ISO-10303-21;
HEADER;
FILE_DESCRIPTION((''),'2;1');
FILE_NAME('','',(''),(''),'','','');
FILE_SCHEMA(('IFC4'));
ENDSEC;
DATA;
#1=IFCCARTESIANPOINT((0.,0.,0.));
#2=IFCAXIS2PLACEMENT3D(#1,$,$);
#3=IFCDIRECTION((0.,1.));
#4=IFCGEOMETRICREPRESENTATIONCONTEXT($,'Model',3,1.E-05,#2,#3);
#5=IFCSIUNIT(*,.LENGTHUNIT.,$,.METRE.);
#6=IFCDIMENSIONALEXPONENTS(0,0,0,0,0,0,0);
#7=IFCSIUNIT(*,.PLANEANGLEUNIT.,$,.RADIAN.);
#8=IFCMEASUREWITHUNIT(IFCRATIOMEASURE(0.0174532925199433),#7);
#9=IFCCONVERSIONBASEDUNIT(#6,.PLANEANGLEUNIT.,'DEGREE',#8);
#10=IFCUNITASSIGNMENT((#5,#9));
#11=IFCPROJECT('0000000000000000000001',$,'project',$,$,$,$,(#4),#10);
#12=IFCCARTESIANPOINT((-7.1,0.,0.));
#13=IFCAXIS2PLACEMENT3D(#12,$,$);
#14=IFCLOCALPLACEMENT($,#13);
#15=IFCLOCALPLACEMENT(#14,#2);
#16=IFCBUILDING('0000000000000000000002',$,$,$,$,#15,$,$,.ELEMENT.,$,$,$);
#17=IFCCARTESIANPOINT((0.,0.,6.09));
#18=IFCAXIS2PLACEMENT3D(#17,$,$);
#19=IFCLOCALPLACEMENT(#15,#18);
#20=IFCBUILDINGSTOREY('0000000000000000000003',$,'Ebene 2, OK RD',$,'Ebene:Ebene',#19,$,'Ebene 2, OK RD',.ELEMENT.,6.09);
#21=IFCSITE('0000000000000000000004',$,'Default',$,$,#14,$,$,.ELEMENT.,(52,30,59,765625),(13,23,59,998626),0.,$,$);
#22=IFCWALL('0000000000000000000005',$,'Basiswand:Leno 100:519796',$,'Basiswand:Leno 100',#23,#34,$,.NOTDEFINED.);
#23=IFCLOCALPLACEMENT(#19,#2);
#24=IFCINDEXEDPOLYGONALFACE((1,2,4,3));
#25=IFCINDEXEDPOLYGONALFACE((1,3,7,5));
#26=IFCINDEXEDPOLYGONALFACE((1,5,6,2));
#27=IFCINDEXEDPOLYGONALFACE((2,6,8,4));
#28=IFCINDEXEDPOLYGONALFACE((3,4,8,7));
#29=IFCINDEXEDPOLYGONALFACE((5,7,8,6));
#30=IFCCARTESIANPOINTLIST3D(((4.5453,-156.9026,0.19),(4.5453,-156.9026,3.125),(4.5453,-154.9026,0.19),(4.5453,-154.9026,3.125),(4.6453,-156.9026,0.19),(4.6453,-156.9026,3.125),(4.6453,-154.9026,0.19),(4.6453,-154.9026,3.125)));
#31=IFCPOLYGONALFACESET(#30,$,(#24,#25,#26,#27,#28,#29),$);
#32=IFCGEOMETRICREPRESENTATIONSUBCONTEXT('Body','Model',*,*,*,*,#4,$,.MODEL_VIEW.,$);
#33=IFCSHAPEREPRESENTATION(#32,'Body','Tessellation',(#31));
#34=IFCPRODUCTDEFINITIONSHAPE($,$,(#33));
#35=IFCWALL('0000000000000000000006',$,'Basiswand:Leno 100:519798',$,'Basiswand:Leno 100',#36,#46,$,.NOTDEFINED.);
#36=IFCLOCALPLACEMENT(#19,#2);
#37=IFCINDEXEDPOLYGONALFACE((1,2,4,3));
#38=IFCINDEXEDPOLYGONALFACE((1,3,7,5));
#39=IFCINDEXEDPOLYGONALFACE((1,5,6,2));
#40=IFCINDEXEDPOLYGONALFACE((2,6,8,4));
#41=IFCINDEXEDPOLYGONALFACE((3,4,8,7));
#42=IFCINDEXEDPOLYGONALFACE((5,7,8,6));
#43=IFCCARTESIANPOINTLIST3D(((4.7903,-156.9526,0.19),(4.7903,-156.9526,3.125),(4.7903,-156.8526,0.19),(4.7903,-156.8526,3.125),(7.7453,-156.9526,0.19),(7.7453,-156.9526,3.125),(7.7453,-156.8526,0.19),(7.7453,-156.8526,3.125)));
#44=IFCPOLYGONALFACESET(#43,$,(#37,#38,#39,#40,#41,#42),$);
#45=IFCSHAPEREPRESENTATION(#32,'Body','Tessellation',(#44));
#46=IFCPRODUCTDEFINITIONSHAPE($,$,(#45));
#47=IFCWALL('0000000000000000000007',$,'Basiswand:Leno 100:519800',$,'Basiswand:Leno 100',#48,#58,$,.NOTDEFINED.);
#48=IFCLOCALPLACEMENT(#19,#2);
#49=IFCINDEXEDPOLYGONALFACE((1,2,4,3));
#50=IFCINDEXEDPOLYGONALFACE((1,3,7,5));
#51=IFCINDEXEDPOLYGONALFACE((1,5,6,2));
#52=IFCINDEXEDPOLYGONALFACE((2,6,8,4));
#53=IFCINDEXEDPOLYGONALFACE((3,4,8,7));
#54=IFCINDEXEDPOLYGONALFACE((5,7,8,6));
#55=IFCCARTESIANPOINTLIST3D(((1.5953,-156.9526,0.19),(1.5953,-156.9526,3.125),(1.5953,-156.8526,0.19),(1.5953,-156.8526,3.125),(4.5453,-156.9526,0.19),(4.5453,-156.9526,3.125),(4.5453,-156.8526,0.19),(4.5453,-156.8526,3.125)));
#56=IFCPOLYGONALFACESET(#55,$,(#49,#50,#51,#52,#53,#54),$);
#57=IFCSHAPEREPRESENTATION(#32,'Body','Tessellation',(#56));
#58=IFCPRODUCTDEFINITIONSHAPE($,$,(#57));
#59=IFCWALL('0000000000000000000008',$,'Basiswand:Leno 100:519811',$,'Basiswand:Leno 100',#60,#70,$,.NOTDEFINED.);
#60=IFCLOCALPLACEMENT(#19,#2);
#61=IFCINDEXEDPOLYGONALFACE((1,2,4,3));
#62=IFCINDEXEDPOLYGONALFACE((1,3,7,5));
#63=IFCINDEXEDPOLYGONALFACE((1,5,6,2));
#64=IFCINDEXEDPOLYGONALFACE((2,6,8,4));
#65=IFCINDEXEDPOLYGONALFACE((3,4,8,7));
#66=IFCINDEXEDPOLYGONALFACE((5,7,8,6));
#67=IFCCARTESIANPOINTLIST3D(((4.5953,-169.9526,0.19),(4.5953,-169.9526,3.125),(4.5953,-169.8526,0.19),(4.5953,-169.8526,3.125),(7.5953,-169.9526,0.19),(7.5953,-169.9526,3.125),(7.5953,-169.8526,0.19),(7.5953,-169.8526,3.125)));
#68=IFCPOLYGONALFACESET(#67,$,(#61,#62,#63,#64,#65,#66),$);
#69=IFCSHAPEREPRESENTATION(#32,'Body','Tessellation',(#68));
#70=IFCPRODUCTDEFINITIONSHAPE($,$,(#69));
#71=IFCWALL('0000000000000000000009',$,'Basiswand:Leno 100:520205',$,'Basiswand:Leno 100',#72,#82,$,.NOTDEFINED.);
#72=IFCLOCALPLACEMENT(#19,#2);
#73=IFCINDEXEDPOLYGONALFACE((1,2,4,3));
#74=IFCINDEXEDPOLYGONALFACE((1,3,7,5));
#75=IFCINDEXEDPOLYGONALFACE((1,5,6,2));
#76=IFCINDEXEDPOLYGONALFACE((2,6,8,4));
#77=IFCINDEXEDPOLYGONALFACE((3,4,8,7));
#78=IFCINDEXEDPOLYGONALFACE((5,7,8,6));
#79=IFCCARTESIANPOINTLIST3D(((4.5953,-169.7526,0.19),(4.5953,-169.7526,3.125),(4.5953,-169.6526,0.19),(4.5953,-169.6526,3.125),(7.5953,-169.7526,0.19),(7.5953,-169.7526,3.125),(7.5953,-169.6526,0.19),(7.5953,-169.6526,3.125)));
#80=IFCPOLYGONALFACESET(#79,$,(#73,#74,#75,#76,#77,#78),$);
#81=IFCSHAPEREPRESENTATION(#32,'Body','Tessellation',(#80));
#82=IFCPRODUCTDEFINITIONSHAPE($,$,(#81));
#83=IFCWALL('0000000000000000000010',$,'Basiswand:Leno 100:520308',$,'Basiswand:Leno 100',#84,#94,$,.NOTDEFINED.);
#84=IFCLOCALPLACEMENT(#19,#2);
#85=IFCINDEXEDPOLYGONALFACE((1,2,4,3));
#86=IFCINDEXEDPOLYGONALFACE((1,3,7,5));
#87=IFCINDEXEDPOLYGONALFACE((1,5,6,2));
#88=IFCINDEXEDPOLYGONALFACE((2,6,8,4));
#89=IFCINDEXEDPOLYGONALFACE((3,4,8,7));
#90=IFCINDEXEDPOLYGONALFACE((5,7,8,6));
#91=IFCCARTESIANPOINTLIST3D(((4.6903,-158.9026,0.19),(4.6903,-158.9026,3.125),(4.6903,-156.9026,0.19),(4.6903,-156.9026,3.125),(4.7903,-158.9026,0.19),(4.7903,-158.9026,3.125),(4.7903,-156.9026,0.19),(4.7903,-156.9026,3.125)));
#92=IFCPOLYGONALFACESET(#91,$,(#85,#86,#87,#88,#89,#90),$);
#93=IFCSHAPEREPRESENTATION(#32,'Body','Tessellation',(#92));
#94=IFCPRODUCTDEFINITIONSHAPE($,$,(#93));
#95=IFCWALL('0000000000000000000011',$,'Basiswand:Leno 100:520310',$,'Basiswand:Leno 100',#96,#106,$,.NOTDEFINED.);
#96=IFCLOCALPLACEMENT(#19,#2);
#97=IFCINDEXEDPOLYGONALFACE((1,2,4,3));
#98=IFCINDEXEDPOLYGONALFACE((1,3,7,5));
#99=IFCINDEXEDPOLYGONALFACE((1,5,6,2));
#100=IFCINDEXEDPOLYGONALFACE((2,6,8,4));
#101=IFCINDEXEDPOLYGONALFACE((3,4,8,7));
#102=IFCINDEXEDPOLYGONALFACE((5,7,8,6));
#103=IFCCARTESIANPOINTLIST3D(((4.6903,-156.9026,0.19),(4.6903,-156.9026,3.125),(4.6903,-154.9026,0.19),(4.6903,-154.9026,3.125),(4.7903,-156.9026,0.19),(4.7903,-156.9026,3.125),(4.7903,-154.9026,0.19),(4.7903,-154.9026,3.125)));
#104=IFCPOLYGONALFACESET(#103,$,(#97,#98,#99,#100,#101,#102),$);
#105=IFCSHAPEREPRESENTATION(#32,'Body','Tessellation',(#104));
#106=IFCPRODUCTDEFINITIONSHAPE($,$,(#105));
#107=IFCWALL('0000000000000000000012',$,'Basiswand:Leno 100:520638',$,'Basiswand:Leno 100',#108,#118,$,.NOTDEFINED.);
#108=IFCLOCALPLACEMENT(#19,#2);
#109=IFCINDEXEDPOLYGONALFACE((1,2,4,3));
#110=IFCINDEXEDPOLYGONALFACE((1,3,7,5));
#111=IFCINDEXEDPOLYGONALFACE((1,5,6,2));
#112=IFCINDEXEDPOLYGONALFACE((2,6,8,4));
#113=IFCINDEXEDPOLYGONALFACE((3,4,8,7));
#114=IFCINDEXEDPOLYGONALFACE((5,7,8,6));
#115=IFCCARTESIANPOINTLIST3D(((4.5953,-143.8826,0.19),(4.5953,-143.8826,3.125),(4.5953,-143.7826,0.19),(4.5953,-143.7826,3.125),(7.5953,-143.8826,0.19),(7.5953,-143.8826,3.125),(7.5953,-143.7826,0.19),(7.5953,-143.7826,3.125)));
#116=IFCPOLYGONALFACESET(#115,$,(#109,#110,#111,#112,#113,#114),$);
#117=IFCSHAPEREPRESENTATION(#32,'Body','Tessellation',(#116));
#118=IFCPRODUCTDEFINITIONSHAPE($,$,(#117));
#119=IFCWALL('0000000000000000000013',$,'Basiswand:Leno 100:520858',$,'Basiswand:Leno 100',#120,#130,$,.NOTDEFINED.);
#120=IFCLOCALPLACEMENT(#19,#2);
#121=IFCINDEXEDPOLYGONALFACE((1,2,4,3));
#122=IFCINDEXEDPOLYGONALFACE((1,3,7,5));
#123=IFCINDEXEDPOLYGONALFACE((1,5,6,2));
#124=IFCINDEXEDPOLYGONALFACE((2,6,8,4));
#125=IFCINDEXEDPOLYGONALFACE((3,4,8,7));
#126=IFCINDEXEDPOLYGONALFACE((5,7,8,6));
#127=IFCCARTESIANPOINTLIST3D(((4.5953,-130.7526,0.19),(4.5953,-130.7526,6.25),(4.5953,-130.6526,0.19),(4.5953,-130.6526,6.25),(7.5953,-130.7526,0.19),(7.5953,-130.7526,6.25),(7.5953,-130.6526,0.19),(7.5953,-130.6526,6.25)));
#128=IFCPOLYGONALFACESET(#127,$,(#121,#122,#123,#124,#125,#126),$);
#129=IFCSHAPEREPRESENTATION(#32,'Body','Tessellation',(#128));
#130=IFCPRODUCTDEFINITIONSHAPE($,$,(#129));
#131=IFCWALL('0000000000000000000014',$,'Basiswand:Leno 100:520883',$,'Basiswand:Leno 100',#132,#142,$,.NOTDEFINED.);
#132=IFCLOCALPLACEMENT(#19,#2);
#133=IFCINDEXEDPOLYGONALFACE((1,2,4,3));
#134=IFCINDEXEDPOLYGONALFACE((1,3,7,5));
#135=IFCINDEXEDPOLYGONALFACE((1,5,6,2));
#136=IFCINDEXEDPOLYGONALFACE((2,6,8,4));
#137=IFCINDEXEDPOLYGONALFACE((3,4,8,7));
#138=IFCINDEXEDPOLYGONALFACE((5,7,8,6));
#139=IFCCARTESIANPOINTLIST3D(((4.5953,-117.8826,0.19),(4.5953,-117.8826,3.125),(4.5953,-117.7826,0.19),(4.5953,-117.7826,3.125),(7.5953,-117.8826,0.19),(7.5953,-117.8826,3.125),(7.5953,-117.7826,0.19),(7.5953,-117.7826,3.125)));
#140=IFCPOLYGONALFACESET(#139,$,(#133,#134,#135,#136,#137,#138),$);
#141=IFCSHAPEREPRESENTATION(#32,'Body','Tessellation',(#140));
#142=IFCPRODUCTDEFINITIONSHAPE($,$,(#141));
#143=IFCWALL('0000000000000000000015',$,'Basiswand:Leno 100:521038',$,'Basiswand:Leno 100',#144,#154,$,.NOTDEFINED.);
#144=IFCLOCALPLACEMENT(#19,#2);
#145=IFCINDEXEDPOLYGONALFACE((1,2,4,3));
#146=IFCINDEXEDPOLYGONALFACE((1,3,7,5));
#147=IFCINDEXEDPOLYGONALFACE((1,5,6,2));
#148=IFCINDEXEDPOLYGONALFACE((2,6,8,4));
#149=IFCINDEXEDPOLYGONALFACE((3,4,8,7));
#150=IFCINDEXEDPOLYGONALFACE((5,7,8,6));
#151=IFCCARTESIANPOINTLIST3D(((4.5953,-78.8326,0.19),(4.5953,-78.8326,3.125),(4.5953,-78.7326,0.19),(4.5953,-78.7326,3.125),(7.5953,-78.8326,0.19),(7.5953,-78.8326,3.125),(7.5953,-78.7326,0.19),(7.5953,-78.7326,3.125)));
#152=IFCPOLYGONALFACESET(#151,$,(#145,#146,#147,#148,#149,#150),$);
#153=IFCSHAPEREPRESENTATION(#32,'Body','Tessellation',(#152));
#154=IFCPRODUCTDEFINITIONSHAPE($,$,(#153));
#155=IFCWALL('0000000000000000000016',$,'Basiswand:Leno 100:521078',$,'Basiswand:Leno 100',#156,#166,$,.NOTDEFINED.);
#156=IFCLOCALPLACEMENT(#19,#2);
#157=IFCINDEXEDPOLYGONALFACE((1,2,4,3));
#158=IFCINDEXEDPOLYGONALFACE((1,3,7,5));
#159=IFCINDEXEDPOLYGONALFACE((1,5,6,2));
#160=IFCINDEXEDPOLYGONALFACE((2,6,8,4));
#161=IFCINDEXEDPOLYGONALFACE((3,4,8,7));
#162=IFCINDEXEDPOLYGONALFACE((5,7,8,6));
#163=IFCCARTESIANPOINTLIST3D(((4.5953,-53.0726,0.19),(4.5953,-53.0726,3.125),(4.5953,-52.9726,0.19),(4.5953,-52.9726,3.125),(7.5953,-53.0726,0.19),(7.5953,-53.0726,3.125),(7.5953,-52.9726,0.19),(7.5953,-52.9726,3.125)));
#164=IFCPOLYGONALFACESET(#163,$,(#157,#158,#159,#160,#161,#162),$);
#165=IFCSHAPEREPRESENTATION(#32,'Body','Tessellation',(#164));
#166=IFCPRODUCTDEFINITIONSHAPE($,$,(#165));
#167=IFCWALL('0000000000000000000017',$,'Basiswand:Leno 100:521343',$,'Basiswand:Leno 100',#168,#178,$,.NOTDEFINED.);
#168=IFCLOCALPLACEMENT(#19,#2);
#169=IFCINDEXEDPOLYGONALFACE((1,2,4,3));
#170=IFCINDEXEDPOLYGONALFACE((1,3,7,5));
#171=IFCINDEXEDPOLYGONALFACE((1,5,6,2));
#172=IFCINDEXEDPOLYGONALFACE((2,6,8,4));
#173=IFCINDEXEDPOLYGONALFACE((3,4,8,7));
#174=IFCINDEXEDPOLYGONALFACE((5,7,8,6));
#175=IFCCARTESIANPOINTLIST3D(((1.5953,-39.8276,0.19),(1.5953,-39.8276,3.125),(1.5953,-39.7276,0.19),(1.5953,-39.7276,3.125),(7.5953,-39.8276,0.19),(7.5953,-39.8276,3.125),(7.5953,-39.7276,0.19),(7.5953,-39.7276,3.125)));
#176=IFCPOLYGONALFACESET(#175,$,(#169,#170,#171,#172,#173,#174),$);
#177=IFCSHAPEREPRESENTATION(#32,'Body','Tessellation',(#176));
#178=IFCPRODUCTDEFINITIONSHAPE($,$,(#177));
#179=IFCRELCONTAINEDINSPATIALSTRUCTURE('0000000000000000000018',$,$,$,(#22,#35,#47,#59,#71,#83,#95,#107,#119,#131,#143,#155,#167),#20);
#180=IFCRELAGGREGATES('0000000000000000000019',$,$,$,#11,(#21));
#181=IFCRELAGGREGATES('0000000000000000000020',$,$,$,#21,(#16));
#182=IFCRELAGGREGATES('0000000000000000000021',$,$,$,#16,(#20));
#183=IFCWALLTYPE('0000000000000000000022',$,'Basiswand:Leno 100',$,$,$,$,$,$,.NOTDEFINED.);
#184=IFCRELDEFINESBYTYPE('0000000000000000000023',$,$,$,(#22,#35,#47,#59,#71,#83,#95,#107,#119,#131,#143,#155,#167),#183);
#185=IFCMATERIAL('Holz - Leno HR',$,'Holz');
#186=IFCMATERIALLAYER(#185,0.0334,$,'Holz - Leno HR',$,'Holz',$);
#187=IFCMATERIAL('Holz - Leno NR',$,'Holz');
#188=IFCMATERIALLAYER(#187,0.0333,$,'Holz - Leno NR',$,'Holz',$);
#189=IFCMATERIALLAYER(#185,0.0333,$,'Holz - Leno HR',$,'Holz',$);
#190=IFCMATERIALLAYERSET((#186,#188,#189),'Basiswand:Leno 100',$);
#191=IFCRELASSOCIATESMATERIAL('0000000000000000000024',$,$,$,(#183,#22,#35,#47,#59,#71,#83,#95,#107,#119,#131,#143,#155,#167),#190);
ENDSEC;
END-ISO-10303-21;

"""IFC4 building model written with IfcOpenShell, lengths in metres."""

from ifc_helpers import new_model, entity, si_unit, converted_unit, direction, frame, origin, place, context, subcontext, project, spatial, indexed_curve, outline, extrude, material, layer, layer_set, type_object, element, save


model = new_model("IFC4")

# Units and contexts
model_context = context("Model", 3, precision=1e-05, world=origin(), true_north=direction((0.0, 1.0)))
body_context = subcontext(model_context, "Body", "Model", "MODEL_VIEW")
ifc_project = project(units=[si_unit("LENGTHUNIT", "METRE"), converted_unit("PLANEANGLEUNIT", "DEGREE", entity("IfcRatioMeasure", 0.0174532925199433), si_unit("PLANEANGLEUNIT", "RADIAN"), dimensions=[0, 0, 0, 0, 0, 0, 0])], contexts=[model_context])

# Site, building, storey
site_placement = place(None, frame((-7.1, 0.0, 0.0)))
site = spatial("IfcSite", under=ifc_project, at=site_placement, Name="Default", CompositionType="ELEMENT", RefLatitude=(52, 30, 59, 765625), RefLongitude=(13, 23, 59, 998626), RefElevation=0.0)
building_placement = place(site_placement, origin())
building = spatial("IfcBuilding", under=site, at=building_placement, CompositionType="ELEMENT")
storey_placement = place(building_placement, frame((0.0, 0.0, 6.09)))
storey = spatial("IfcBuildingStorey", under=building, at=storey_placement, Name="Ebene 2, OK RD", ObjectType="Ebene:Ebene", LongName="Ebene 2, OK RD", CompositionType="ELEMENT", Elevation=6.09)

# Walls
ifc_material_1 = material(Name="Holz - Leno HR", Category="Holz")
ifc_layer_1 = layer(ifc_material_1, 0.0334, Name="Holz - Leno HR", Category="Holz")
ifc_material_2 = material(Name="Holz - Leno NR", Category="Holz")
ifc_layer_2 = layer(ifc_material_2, 0.0333, Name="Holz - Leno NR", Category="Holz")
ifc_layer_3 = layer(ifc_material_1, 0.0333, Name="Holz - Leno HR", Category="Holz")
ifc_layer_set = layer_set([ifc_layer_1, ifc_layer_2, ifc_layer_3], Name="Basiswand:Leno 100")
wall_type = type_object("IfcWallType", Name="Basiswand:Leno 100", PredefinedType="NOTDEFINED", material=ifc_layer_set)
wall_1_placement = place(storey_placement, frame((4.5953, -154.9026, 0.19), z_axis=(0.0, 0.0, 1.0), x_axis=(0.0, -1.0, 0.0)))
element("IfcWall", 1, at=wall_1_placement, inside=storey, type_object=wall_type, material=ifc_layer_set, Name="Basiswand:Leno 100:519796", ObjectType="Basiswand:Leno 100", PredefinedType="NOTDEFINED", context=body_context, shape_type="SweptSolid", body=[
    extrude(outline(indexed_curve([(2.0, 0.05), (0.0, 0.05), (0.0, -0.05), (2.0, -0.05), (2.0, 0.05)], self_intersect=False)), origin(), (0.0, 0.0, 1.0), 2.935),
])
wall_2_placement = place(storey_placement, frame((7.7453, -156.9026, 0.19), z_axis=(0.0, 0.0, 1.0), x_axis=(-1.0, 0.0, 0.0)))
element("IfcWall", 2, at=wall_2_placement, inside=storey, type_object=wall_type, material=ifc_layer_set, Name="Basiswand:Leno 100:519798", ObjectType="Basiswand:Leno 100", PredefinedType="NOTDEFINED", context=body_context, shape_type="SweptSolid", body=[
    extrude(outline(indexed_curve([(2.955, 0.05), (0.0, 0.05), (0.0, -0.05), (2.955, -0.05), (2.955, 0.05)], self_intersect=False)), origin(), (0.0, 0.0, 1.0), 2.935),
])
wall_3_placement = place(storey_placement, frame((1.5953, -156.9026, 0.19)))
element("IfcWall", 3, at=wall_3_placement, inside=storey, type_object=wall_type, material=ifc_layer_set, Name="Basiswand:Leno 100:519800", ObjectType="Basiswand:Leno 100", PredefinedType="NOTDEFINED", context=body_context, shape_type="SweptSolid", body=[
    extrude(outline(indexed_curve([(2.95, 0.05), (0.0, 0.05), (0.0, -0.05), (2.95, -0.05), (2.95, 0.05)], self_intersect=False)), origin(), (0.0, 0.0, 1.0), 2.935),
])
for number, where, z_axis, x_axis, name in (
    (4, (7.5953, -169.9026, 0.19), (0.0, 0.0, 1.0), (-1.0, 0.0, 0.0), "Basiswand:Leno 100:519811"),
    (5, (7.5953, -169.7026, 0.19), (0.0, 0.0, 1.0), (-1.0, 0.0, 0.0), "Basiswand:Leno 100:520205"),
):
    element("IfcWall", number, at=place(storey_placement, frame(where, z_axis=z_axis, x_axis=x_axis)), inside=storey, type_object=wall_type, material=ifc_layer_set, Name=name, ObjectType="Basiswand:Leno 100", PredefinedType="NOTDEFINED", context=body_context, shape_type="SweptSolid", body=[
        extrude(outline(indexed_curve([(3.0, 0.05), (0.0, 0.05), (0.0, -0.05), (3.0, -0.05), (3.0, 0.05)], self_intersect=False)), origin(), (0.0, 0.0, 1.0), 2.935),
    ])
wall_4_placement = place(storey_placement, frame((4.7403, -158.9026, 0.19), z_axis=(0.0, 0.0, 1.0), x_axis=(0.0, 1.0, 0.0)))
element("IfcWall", 6, at=wall_4_placement, inside=storey, type_object=wall_type, material=ifc_layer_set, Name="Basiswand:Leno 100:520308", ObjectType="Basiswand:Leno 100", PredefinedType="NOTDEFINED", context=body_context, shape_type="SweptSolid", body=[
    extrude(outline(indexed_curve([(2.0, 0.05), (0.0, 0.05), (0.0, -0.05), (2.0, -0.05), (2.0, 0.05)], self_intersect=False)), origin(), (0.0, 0.0, 1.0), 2.935),
])
wall_5_placement = place(storey_placement, frame((4.7403, -154.9026, 0.19), z_axis=(0.0, 0.0, 1.0), x_axis=(0.0, -1.0, 0.0)))
element("IfcWall", 7, at=wall_5_placement, inside=storey, type_object=wall_type, material=ifc_layer_set, Name="Basiswand:Leno 100:520310", ObjectType="Basiswand:Leno 100", PredefinedType="NOTDEFINED", context=body_context, shape_type="SweptSolid", body=[
    extrude(outline(indexed_curve([(2.0, 0.05), (0.0, 0.05), (0.0, -0.05), (2.0, -0.05), (2.0, 0.05)], self_intersect=False)), origin(), (0.0, 0.0, 1.0), 2.935),
])
wall_6_placement = place(storey_placement, frame((7.5953, -143.8326, 0.19), z_axis=(0.0, 0.0, 1.0), x_axis=(-1.0, 0.0, 0.0)))
element("IfcWall", 8, at=wall_6_placement, inside=storey, type_object=wall_type, material=ifc_layer_set, Name="Basiswand:Leno 100:520638", ObjectType="Basiswand:Leno 100", PredefinedType="NOTDEFINED", context=body_context, shape_type="SweptSolid", body=[
    extrude(outline(indexed_curve([(3.0, 0.05), (0.0, 0.05), (0.0, -0.05), (3.0, -0.05), (3.0, 0.05)], self_intersect=False)), origin(), (0.0, 0.0, 1.0), 2.935),
])
wall_7_placement = place(storey_placement, frame((7.5953, -130.7026, 0.19), z_axis=(0.0, 0.0, 1.0), x_axis=(-1.0, 0.0, 0.0)))
element("IfcWall", 9, at=wall_7_placement, inside=storey, type_object=wall_type, material=ifc_layer_set, Name="Basiswand:Leno 100:520858", ObjectType="Basiswand:Leno 100", PredefinedType="NOTDEFINED", context=body_context, shape_type="SweptSolid", body=[
    extrude(outline(indexed_curve([(3.0, 0.05), (0.0, 0.05), (0.0, -0.05), (3.0, -0.05), (3.0, 0.05)], self_intersect=False)), origin(), (0.0, 0.0, 1.0), 6.06),
])
for number, where, z_axis, x_axis, name in (
    (10, (7.5953, -117.8326, 0.19), (0.0, 0.0, 1.0), (-1.0, 0.0, 0.0), "Basiswand:Leno 100:520883"),
    (11, (7.5953, -78.7826, 0.19), (0.0, 0.0, 1.0), (-1.0, 0.0, 0.0), "Basiswand:Leno 100:521038"),
):
    element("IfcWall", number, at=place(storey_placement, frame(where, z_axis=z_axis, x_axis=x_axis)), inside=storey, type_object=wall_type, material=ifc_layer_set, Name=name, ObjectType="Basiswand:Leno 100", PredefinedType="NOTDEFINED", context=body_context, shape_type="SweptSolid", body=[
        extrude(outline(indexed_curve([(3.0, 0.05), (0.0, 0.05), (0.0, -0.05), (3.0, -0.05), (3.0, 0.05)], self_intersect=False)), origin(), (0.0, 0.0, 1.0), 2.935),
    ])
wall_8_placement = place(storey_placement, frame((7.5953, -53.0226, 0.19), z_axis=(0.0, 0.0, 1.0), x_axis=(-1.0, 0.0, 0.0)))
element("IfcWall", 12, at=wall_8_placement, inside=storey, type_object=wall_type, material=ifc_layer_set, Name="Basiswand:Leno 100:521078", ObjectType="Basiswand:Leno 100", PredefinedType="NOTDEFINED", context=body_context, shape_type="SweptSolid", body=[
    extrude(outline(indexed_curve([(3.0, 0.05), (0.0, 0.05), (0.0, -0.05), (3.0, -0.05), (3.0, 0.05)], self_intersect=False)), origin(), (0.0, 0.0, 1.0), 2.935),
])
wall_9_placement = place(storey_placement, frame((1.5953, -39.7776, 0.19)))
element("IfcWall", 13, at=wall_9_placement, inside=storey, type_object=wall_type, material=ifc_layer_set, Name="Basiswand:Leno 100:521343", ObjectType="Basiswand:Leno 100", PredefinedType="NOTDEFINED", context=body_context, shape_type="SweptSolid", body=[
    extrude(outline(indexed_curve([(6.0, 0.05), (0.0, 0.05), (0.0, -0.05), (6.0, -0.05), (6.0, 0.05)], self_intersect=False)), origin(), (0.0, 0.0, 1.0), 2.935),
])

save(model, "model.ifc")
